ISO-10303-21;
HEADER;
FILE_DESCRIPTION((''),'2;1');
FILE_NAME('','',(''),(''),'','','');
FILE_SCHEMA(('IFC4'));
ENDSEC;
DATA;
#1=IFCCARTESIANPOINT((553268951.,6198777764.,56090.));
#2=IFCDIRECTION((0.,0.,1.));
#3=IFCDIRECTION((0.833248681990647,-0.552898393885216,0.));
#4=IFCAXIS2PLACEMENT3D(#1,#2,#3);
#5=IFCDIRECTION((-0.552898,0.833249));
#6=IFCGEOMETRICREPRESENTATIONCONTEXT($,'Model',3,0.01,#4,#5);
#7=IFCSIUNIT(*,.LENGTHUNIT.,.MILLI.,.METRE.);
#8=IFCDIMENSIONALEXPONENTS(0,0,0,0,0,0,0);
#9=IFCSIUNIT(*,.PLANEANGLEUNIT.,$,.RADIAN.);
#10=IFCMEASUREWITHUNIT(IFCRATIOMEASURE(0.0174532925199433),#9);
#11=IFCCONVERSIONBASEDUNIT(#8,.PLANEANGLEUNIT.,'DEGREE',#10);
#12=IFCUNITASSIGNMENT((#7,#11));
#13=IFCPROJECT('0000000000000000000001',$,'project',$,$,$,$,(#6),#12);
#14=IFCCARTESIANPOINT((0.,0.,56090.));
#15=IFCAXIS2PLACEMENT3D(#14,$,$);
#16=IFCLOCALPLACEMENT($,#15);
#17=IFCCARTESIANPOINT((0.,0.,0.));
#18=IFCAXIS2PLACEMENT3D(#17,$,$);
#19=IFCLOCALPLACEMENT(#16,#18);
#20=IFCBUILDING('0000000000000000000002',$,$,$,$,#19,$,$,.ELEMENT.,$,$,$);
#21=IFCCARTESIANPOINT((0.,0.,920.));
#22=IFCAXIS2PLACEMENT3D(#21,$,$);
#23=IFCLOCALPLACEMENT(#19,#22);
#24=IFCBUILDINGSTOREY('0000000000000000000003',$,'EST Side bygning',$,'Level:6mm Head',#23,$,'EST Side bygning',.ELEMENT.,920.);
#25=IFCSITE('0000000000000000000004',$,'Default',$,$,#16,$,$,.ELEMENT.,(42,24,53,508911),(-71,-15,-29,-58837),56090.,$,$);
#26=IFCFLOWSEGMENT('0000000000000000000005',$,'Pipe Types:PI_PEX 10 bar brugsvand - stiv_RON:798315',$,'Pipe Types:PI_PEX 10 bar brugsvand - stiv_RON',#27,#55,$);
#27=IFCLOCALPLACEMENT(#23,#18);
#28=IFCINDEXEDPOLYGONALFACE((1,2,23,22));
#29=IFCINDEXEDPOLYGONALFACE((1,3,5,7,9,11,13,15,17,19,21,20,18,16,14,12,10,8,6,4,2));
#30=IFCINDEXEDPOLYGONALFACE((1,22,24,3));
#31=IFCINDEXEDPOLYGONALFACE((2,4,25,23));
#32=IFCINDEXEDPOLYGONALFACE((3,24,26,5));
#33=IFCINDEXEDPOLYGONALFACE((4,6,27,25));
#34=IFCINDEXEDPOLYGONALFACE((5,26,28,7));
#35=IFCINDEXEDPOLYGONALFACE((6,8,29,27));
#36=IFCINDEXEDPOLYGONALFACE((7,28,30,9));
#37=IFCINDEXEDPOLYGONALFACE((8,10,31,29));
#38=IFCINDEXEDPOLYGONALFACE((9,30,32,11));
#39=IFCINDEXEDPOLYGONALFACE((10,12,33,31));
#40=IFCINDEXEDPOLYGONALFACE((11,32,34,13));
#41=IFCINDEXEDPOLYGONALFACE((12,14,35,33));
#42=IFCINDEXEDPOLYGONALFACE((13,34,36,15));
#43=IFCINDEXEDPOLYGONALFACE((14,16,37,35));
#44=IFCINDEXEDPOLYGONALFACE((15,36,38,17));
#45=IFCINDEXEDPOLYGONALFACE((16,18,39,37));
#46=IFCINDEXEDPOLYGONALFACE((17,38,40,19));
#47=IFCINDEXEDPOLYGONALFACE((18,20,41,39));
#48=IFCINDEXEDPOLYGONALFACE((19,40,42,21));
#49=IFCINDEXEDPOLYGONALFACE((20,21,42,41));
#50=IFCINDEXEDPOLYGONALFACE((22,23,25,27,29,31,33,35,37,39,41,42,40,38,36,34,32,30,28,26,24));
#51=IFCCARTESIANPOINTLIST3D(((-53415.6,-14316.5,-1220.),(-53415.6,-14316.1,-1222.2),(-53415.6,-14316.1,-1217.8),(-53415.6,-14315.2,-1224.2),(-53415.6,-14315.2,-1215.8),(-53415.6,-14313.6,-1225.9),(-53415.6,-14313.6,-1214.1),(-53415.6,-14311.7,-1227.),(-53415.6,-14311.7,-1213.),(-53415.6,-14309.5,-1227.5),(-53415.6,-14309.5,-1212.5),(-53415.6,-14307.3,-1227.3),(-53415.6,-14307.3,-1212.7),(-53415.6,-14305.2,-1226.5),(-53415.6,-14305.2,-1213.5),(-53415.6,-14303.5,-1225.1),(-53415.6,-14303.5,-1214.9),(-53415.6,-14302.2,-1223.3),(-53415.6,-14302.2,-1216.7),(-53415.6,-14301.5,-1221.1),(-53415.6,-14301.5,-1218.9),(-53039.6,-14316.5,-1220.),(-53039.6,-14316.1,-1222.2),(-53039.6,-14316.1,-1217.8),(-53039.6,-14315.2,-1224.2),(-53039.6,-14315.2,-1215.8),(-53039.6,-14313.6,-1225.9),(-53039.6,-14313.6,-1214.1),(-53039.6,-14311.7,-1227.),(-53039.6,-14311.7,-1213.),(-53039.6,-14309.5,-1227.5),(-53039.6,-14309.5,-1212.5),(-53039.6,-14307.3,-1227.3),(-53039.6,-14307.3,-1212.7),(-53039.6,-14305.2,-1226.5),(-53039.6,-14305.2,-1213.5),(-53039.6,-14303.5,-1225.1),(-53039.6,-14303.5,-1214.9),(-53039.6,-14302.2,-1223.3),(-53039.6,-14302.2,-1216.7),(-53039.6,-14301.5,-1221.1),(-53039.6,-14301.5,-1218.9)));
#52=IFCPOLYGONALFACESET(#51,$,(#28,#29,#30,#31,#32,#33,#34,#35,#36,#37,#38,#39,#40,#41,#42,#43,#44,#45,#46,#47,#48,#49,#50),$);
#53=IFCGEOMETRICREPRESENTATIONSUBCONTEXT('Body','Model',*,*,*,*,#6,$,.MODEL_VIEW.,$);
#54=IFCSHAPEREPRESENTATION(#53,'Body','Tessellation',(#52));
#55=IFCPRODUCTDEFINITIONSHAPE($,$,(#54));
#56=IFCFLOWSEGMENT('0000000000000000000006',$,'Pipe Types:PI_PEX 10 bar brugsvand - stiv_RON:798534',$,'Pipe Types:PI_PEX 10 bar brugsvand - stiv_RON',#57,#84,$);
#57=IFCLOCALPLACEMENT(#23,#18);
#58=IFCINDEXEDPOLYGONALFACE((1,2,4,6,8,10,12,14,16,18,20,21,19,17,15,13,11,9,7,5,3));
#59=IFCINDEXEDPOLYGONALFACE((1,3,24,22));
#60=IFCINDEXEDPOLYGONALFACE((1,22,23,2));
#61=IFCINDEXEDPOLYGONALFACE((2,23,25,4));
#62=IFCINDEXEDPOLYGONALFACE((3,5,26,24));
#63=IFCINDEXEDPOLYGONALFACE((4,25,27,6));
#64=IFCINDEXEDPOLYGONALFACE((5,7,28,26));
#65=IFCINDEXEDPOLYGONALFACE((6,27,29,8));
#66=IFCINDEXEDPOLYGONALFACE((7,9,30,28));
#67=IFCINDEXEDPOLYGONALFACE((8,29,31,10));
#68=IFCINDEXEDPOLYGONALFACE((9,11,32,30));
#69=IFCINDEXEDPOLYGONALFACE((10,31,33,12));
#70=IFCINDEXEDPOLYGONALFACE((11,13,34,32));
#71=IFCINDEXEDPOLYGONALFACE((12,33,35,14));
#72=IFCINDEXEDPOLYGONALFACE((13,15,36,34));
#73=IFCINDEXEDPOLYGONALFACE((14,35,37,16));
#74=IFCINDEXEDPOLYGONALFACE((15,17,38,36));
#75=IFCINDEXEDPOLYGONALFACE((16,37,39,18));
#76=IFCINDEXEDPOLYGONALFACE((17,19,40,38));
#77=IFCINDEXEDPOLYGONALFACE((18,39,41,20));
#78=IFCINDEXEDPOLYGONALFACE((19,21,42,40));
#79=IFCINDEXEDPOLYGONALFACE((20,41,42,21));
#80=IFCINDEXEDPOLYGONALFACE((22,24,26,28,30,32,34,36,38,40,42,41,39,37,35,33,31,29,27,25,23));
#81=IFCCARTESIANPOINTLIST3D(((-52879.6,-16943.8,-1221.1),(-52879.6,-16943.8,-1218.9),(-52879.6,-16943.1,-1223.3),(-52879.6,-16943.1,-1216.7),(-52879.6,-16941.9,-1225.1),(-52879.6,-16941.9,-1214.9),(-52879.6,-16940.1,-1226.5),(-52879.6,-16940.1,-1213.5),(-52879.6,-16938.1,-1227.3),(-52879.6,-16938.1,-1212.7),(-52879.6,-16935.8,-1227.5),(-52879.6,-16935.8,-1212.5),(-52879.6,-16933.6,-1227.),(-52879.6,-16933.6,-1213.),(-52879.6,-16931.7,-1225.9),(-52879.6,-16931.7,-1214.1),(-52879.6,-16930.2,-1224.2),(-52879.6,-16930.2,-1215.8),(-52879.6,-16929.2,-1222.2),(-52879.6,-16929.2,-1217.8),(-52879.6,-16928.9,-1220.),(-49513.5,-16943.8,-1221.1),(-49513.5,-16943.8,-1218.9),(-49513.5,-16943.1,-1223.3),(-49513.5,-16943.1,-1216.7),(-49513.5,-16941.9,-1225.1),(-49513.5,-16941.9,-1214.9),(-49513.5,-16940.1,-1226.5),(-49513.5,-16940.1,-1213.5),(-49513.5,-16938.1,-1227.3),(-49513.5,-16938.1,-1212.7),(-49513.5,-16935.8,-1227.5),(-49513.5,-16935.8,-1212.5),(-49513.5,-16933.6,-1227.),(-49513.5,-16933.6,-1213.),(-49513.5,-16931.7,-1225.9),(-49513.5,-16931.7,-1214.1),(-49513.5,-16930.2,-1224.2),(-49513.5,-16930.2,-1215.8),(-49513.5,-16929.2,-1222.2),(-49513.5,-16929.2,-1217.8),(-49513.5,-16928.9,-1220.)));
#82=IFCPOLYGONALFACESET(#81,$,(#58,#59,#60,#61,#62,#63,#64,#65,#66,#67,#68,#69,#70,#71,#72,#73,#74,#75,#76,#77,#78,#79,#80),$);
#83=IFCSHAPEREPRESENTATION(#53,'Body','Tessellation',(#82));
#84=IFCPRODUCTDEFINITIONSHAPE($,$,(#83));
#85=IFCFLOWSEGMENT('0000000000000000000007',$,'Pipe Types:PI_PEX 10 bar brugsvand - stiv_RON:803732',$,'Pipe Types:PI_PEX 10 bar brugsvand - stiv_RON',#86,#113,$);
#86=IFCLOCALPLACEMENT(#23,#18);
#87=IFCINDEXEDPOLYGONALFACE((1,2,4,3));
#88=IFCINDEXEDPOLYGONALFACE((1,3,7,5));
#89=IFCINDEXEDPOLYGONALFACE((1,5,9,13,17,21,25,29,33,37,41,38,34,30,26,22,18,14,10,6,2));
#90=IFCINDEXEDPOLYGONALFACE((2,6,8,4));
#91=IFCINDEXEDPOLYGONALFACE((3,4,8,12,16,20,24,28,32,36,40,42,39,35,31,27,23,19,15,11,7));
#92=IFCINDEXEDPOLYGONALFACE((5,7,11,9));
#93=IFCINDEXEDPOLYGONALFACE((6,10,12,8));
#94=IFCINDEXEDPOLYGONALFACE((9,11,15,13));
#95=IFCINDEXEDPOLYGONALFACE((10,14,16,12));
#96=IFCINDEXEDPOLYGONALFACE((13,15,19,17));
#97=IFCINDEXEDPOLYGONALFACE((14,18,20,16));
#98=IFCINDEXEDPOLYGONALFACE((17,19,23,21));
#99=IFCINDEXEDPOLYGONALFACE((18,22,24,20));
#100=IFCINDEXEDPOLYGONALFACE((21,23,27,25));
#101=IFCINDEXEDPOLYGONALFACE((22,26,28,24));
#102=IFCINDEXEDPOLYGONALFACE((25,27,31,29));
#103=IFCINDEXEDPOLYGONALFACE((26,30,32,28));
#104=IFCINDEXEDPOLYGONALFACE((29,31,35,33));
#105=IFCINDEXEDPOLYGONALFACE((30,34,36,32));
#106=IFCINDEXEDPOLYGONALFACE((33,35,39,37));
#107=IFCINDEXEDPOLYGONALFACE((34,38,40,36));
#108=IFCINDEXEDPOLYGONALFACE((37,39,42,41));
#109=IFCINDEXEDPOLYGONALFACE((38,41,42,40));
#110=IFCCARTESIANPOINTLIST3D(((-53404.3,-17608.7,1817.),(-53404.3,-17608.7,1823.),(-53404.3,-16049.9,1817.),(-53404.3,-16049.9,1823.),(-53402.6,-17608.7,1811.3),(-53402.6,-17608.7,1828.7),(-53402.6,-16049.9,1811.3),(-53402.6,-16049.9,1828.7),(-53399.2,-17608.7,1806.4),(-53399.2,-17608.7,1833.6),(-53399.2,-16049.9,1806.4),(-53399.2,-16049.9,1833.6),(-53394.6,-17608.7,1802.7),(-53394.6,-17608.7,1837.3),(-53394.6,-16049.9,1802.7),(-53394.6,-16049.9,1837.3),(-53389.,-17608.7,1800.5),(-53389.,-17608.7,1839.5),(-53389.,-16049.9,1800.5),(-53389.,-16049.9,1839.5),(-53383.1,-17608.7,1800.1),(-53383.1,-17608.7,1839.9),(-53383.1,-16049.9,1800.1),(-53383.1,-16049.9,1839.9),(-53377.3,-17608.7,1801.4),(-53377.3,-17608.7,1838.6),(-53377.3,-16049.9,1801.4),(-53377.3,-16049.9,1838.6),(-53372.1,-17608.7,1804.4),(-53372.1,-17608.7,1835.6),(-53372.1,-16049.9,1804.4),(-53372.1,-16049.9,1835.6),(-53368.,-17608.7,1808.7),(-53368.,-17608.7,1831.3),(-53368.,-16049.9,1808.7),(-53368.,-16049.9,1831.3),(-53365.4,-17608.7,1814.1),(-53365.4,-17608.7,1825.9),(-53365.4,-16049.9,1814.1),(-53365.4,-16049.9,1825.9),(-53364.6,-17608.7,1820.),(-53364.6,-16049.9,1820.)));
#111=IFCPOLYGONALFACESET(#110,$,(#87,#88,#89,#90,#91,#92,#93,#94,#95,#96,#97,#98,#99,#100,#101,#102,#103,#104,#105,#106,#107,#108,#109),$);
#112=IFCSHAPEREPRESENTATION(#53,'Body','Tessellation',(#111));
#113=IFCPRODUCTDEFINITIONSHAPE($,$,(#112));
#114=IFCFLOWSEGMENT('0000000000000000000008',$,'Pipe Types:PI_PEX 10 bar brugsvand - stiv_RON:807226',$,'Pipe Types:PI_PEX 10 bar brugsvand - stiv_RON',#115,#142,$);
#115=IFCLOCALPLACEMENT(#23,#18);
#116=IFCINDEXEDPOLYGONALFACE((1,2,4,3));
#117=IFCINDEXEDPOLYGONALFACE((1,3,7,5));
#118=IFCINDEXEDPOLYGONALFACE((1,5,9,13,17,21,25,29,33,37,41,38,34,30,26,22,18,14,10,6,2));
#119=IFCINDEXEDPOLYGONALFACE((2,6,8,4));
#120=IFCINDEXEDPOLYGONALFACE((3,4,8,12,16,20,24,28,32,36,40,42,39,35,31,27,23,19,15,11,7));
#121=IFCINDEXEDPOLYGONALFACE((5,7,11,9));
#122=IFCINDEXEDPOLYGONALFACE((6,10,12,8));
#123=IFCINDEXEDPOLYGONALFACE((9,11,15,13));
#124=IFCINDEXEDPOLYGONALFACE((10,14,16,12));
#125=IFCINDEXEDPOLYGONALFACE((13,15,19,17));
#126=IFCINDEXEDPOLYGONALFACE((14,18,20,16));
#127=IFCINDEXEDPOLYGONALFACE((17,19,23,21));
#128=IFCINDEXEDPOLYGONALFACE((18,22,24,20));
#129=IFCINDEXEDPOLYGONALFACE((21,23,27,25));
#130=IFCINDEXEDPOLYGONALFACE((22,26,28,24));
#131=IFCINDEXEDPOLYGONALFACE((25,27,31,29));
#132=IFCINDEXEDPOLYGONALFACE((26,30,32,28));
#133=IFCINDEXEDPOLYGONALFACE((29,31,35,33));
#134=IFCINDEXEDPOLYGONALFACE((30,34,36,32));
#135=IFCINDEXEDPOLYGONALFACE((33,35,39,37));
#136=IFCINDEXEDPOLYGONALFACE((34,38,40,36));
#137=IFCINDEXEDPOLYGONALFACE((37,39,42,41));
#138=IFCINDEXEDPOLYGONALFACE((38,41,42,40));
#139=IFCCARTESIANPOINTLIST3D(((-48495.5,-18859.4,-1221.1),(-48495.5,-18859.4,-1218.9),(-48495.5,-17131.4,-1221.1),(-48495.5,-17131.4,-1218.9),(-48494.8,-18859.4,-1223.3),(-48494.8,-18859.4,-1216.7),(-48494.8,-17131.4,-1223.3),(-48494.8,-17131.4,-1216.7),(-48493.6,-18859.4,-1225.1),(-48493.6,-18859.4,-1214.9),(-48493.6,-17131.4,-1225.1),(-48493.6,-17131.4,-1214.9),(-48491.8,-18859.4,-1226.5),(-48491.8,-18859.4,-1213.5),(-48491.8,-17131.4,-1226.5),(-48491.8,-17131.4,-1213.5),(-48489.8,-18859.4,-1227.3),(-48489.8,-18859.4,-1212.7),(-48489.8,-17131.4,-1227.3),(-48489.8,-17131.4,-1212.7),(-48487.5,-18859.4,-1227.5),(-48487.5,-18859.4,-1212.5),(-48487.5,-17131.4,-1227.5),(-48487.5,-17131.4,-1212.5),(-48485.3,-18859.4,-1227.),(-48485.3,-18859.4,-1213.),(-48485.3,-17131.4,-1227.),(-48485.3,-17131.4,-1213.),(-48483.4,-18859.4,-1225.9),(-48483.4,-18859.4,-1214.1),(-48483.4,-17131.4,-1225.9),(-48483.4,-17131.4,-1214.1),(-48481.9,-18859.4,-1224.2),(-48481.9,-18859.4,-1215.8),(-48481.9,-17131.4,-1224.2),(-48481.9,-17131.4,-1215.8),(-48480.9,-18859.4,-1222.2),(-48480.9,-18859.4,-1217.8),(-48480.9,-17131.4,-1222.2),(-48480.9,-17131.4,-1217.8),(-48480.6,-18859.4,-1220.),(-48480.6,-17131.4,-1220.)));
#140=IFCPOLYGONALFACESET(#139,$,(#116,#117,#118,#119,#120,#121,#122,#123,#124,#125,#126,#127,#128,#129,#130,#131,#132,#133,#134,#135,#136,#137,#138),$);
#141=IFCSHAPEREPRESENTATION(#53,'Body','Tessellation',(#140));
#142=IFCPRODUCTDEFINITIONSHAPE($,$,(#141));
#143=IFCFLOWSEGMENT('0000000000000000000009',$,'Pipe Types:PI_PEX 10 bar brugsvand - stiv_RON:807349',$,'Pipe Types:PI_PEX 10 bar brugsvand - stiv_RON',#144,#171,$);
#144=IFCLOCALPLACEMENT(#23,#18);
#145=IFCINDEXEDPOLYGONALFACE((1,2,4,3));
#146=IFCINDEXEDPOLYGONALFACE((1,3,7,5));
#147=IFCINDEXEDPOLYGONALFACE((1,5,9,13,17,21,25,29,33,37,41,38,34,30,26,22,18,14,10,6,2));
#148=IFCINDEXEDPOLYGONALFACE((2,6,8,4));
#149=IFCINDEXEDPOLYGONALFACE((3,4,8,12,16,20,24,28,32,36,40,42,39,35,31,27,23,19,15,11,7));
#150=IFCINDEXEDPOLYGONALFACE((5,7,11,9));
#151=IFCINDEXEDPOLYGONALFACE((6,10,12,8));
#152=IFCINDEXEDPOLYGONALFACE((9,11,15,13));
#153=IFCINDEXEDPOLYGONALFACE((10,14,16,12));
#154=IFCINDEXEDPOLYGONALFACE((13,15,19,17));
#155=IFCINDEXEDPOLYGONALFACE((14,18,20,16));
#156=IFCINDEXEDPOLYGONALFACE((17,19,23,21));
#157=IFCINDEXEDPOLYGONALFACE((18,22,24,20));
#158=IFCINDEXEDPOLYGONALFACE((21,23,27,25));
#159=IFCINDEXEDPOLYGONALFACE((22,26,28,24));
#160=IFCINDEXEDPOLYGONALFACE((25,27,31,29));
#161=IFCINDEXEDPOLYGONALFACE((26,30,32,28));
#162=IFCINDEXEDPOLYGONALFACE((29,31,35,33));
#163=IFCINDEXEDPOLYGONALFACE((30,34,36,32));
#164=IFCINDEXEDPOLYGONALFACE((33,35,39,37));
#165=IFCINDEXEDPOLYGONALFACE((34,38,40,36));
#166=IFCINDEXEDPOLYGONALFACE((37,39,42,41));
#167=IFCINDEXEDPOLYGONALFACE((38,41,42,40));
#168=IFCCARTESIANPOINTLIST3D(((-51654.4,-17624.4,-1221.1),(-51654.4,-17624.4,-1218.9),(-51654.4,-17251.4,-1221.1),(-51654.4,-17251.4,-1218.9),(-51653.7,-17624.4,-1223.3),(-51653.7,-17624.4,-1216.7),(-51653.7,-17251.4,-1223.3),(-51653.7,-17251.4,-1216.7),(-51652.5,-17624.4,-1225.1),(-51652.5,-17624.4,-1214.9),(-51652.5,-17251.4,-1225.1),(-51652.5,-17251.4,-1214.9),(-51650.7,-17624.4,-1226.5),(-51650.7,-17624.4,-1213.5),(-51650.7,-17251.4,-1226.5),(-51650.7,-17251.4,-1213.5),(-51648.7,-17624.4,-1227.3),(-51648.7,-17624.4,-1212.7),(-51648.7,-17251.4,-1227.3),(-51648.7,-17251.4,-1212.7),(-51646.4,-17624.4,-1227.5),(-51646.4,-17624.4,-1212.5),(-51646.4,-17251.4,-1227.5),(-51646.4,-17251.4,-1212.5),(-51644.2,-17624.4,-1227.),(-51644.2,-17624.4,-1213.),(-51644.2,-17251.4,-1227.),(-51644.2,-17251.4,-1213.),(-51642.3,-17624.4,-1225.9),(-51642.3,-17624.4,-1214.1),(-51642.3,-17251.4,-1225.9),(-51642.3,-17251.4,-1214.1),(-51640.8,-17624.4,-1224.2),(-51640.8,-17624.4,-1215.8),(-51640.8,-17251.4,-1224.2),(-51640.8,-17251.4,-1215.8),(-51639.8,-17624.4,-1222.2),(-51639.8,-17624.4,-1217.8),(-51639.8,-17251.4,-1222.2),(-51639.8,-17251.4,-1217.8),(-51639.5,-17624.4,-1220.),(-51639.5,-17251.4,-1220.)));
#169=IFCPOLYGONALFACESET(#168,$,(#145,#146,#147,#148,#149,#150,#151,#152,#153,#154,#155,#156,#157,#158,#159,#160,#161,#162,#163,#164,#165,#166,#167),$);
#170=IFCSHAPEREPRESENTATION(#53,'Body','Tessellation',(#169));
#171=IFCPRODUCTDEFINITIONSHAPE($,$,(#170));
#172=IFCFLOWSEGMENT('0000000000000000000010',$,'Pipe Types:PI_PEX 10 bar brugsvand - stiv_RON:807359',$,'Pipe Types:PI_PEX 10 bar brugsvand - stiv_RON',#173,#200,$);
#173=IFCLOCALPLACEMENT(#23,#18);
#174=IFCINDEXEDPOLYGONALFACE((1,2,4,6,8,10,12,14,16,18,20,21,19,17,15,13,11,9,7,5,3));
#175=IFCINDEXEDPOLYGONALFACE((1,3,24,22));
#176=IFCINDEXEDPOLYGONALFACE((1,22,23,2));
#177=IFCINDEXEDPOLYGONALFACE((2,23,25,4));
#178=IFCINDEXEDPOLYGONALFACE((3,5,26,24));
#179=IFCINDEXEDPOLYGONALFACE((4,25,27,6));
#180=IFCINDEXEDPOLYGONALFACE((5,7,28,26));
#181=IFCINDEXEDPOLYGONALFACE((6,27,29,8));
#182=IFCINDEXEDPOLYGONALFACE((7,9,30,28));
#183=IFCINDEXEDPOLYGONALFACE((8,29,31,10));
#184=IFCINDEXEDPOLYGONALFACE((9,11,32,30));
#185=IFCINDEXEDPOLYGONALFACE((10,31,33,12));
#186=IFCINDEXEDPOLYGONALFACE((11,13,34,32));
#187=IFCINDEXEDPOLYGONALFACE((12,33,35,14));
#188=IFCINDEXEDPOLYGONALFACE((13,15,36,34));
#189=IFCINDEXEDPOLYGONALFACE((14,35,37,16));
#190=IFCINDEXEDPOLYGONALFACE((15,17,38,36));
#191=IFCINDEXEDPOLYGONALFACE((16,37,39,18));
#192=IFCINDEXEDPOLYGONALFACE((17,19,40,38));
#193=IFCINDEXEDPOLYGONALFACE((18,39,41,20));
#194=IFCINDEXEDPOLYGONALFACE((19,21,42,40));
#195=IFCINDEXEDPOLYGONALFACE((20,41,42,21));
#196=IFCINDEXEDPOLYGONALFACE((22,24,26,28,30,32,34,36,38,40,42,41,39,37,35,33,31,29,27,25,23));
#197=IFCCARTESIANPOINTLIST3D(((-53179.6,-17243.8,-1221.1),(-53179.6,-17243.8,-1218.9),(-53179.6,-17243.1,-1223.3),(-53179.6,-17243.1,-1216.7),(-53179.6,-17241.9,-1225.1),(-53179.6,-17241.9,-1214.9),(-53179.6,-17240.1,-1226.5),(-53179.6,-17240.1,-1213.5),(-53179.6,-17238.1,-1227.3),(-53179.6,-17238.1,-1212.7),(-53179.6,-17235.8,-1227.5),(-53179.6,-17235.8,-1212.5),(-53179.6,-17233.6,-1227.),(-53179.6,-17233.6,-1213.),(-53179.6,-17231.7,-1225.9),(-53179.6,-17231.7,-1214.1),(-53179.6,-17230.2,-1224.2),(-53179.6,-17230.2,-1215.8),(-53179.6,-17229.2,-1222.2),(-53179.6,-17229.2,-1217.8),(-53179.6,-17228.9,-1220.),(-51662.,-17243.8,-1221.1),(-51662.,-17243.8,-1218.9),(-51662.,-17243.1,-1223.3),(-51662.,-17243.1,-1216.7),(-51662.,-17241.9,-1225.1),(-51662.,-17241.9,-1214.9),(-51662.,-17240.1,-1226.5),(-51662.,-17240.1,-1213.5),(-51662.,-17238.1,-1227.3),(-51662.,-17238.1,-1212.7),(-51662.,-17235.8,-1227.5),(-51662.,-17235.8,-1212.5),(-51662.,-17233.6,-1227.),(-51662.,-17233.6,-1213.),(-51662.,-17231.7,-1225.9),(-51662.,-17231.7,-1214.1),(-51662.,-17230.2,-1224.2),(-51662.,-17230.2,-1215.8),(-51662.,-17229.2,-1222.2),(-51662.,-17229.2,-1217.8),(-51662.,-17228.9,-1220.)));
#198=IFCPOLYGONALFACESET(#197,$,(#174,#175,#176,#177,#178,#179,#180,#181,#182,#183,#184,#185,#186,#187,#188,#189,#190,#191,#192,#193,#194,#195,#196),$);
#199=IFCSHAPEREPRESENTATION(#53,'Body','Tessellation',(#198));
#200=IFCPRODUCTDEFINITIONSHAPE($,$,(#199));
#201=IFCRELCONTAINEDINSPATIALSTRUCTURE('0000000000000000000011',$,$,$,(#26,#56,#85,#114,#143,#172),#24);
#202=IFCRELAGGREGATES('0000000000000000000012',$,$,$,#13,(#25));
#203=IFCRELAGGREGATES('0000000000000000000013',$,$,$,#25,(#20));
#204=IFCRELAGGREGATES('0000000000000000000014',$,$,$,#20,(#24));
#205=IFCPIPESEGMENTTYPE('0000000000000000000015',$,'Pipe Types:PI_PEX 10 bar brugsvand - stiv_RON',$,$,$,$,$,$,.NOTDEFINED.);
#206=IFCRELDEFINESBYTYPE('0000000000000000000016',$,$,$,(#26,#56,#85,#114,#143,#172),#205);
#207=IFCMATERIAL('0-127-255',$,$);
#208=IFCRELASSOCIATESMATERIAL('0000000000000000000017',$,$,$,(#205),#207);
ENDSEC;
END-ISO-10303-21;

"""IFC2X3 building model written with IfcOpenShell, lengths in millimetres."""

from ifc_helpers import new_model, entity, si_unit, converted_unit, direction, frame, frame_2d, origin, origin_2d_with_axis, place, context, subcontext, project, spatial, circle, extrude, material, type_object, element, save


model = new_model("IFC2X3")

# Units and contexts
model_context = context("Model", 3, precision=0.01, world=frame((553268951.0, 6198777764.0, 56090.0), z_axis=(0.0, 0.0, 1.0), x_axis=(0.833248681990647, -0.552898393885216, 0.0)), true_north=direction((-0.552898, 0.833249)))
body_context = subcontext(model_context, "Body", "Model", "MODEL_VIEW")
ifc_project = project(units=[si_unit("LENGTHUNIT", "METRE", prefix="MILLI"), converted_unit("PLANEANGLEUNIT", "DEGREE", entity("IfcRatioMeasure", 0.0174532925199433), si_unit("PLANEANGLEUNIT", "RADIAN"), dimensions=[0, 0, 0, 0, 0, 0, 0])], contexts=[model_context])

# Site, building, storey
site_placement = place(None, frame((0.0, 0.0, 56090.0)))
site = spatial("IfcSite", under=ifc_project, at=site_placement, Name="Default", CompositionType="ELEMENT", RefLatitude=(42, 24, 53, 508911), RefLongitude=(-71, -15, -29, -58837), RefElevation=56090.0)
building_placement = place(site_placement, origin())
building = spatial("IfcBuilding", under=site, at=building_placement, CompositionType="ELEMENT")
storey_placement = place(building_placement, frame((0.0, 0.0, 920.0)))
storey = spatial("IfcBuildingStorey", under=building, at=storey_placement, Name="EST Side bygning", ObjectType="Level:6mm Head", LongName="EST Side bygning", CompositionType="ELEMENT", Elevation=920.0)

# Flow segments
ifc_material_1 = material(Name="0-127-255")
pipe_segment_type_1 = type_object("IfcPipeSegmentType", Name="Pipe Types:PI_PEX 10 bar brugsvand - stiv_RON", PredefinedType="NOTDEFINED", material=ifc_material_1)
flow_segment_1_placement = place(storey_placement, origin())
element("IfcFlowSegment", 1, at=flow_segment_1_placement, inside=storey, type_object=pipe_segment_type_1, Name="Pipe Types:PI_PEX 10 bar brugsvand - stiv_RON:798315", ObjectType="Pipe Types:PI_PEX 10 bar brugsvand - stiv_RON", context=body_context, shape_type="SweptSolid", body=[
    extrude(circle(Radius=7.5, at=origin_2d_with_axis()), frame((-53415.6, -14309.0, -1220.0), z_axis=(1.0, 0.0, 0.0), x_axis=(0.0, -1.0, 0.0)), (0.0, 0.0, 1.0), 376.0),
])
flow_segment_2_placement = place(storey_placement, origin())
element("IfcFlowSegment", 2, at=flow_segment_2_placement, inside=storey, type_object=pipe_segment_type_1, Name="Pipe Types:PI_PEX 10 bar brugsvand - stiv_RON:798534", ObjectType="Pipe Types:PI_PEX 10 bar brugsvand - stiv_RON", context=body_context, shape_type="SweptSolid", body=[
    extrude(circle(Radius=7.5, at=frame_2d((0.0, 0.0), x_axis=(1.0, 0.0))), frame((-52879.6, -16936.4, -1220.0), z_axis=(1.0, 0.0, 0.0), x_axis=(0.0, 1.0, 0.0)), (0.0, 0.0, 1.0), 3366.0),
])
flow_segment_3_placement = place(storey_placement, origin())
element("IfcFlowSegment", 3, at=flow_segment_3_placement, inside=storey, type_object=pipe_segment_type_1, Name="Pipe Types:PI_PEX 10 bar brugsvand - stiv_RON:803732", ObjectType="Pipe Types:PI_PEX 10 bar brugsvand - stiv_RON", context=body_context, shape_type="SweptSolid", body=[
    extrude(circle(Radius=20.0, at=origin_2d_with_axis()), frame((-53384.6, -17608.7, 1820.0), z_axis=(0.0, 1.0, 0.0), x_axis=(1.0, 0.0, 0.0)), (0.0, 0.0, 1.0), 1558.8),
])
flow_segment_4_placement = place(storey_placement, origin())
element("IfcFlowSegment", 4, at=flow_segment_4_placement, inside=storey, type_object=pipe_segment_type_1, Name="Pipe Types:PI_PEX 10 bar brugsvand - stiv_RON:807226", ObjectType="Pipe Types:PI_PEX 10 bar brugsvand - stiv_RON", context=body_context, shape_type="SweptSolid", body=[
    extrude(circle(Radius=7.5, at=origin_2d_with_axis()), frame((-48488.1, -18859.4, -1220.0), z_axis=(0.0, 1.0, 0.0), x_axis=(1.0, 0.0, 0.0)), (0.0, 0.0, 1.0), 1728.0),
])
flow_segment_5_placement = place(storey_placement, origin())
element("IfcFlowSegment", 5, at=flow_segment_5_placement, inside=storey, type_object=pipe_segment_type_1, Name="Pipe Types:PI_PEX 10 bar brugsvand - stiv_RON:807349", ObjectType="Pipe Types:PI_PEX 10 bar brugsvand - stiv_RON", context=body_context, shape_type="SweptSolid", body=[
    extrude(circle(Radius=7.5, at=origin_2d_with_axis()), frame((-51647.0, -17624.4, -1220.0), z_axis=(0.0, 1.0, 0.0), x_axis=(1.0, 0.0, 0.0)), (0.0, 0.0, 1.0), 373.0),
])
flow_segment_6_placement = place(storey_placement, origin())
element("IfcFlowSegment", 6, at=flow_segment_6_placement, inside=storey, type_object=pipe_segment_type_1, Name="Pipe Types:PI_PEX 10 bar brugsvand - stiv_RON:807359", ObjectType="Pipe Types:PI_PEX 10 bar brugsvand - stiv_RON", context=body_context, shape_type="SweptSolid", body=[
    extrude(circle(Radius=7.5, at=frame_2d((0.0, 0.0), x_axis=(1.0, 0.0))), frame((-53179.6, -17236.4, -1220.0), z_axis=(1.0, 0.0, 0.0), x_axis=(0.0, 1.0, 0.0)), (0.0, 0.0, 1.0), 1517.6),
])

save(model, "model.ifc")
